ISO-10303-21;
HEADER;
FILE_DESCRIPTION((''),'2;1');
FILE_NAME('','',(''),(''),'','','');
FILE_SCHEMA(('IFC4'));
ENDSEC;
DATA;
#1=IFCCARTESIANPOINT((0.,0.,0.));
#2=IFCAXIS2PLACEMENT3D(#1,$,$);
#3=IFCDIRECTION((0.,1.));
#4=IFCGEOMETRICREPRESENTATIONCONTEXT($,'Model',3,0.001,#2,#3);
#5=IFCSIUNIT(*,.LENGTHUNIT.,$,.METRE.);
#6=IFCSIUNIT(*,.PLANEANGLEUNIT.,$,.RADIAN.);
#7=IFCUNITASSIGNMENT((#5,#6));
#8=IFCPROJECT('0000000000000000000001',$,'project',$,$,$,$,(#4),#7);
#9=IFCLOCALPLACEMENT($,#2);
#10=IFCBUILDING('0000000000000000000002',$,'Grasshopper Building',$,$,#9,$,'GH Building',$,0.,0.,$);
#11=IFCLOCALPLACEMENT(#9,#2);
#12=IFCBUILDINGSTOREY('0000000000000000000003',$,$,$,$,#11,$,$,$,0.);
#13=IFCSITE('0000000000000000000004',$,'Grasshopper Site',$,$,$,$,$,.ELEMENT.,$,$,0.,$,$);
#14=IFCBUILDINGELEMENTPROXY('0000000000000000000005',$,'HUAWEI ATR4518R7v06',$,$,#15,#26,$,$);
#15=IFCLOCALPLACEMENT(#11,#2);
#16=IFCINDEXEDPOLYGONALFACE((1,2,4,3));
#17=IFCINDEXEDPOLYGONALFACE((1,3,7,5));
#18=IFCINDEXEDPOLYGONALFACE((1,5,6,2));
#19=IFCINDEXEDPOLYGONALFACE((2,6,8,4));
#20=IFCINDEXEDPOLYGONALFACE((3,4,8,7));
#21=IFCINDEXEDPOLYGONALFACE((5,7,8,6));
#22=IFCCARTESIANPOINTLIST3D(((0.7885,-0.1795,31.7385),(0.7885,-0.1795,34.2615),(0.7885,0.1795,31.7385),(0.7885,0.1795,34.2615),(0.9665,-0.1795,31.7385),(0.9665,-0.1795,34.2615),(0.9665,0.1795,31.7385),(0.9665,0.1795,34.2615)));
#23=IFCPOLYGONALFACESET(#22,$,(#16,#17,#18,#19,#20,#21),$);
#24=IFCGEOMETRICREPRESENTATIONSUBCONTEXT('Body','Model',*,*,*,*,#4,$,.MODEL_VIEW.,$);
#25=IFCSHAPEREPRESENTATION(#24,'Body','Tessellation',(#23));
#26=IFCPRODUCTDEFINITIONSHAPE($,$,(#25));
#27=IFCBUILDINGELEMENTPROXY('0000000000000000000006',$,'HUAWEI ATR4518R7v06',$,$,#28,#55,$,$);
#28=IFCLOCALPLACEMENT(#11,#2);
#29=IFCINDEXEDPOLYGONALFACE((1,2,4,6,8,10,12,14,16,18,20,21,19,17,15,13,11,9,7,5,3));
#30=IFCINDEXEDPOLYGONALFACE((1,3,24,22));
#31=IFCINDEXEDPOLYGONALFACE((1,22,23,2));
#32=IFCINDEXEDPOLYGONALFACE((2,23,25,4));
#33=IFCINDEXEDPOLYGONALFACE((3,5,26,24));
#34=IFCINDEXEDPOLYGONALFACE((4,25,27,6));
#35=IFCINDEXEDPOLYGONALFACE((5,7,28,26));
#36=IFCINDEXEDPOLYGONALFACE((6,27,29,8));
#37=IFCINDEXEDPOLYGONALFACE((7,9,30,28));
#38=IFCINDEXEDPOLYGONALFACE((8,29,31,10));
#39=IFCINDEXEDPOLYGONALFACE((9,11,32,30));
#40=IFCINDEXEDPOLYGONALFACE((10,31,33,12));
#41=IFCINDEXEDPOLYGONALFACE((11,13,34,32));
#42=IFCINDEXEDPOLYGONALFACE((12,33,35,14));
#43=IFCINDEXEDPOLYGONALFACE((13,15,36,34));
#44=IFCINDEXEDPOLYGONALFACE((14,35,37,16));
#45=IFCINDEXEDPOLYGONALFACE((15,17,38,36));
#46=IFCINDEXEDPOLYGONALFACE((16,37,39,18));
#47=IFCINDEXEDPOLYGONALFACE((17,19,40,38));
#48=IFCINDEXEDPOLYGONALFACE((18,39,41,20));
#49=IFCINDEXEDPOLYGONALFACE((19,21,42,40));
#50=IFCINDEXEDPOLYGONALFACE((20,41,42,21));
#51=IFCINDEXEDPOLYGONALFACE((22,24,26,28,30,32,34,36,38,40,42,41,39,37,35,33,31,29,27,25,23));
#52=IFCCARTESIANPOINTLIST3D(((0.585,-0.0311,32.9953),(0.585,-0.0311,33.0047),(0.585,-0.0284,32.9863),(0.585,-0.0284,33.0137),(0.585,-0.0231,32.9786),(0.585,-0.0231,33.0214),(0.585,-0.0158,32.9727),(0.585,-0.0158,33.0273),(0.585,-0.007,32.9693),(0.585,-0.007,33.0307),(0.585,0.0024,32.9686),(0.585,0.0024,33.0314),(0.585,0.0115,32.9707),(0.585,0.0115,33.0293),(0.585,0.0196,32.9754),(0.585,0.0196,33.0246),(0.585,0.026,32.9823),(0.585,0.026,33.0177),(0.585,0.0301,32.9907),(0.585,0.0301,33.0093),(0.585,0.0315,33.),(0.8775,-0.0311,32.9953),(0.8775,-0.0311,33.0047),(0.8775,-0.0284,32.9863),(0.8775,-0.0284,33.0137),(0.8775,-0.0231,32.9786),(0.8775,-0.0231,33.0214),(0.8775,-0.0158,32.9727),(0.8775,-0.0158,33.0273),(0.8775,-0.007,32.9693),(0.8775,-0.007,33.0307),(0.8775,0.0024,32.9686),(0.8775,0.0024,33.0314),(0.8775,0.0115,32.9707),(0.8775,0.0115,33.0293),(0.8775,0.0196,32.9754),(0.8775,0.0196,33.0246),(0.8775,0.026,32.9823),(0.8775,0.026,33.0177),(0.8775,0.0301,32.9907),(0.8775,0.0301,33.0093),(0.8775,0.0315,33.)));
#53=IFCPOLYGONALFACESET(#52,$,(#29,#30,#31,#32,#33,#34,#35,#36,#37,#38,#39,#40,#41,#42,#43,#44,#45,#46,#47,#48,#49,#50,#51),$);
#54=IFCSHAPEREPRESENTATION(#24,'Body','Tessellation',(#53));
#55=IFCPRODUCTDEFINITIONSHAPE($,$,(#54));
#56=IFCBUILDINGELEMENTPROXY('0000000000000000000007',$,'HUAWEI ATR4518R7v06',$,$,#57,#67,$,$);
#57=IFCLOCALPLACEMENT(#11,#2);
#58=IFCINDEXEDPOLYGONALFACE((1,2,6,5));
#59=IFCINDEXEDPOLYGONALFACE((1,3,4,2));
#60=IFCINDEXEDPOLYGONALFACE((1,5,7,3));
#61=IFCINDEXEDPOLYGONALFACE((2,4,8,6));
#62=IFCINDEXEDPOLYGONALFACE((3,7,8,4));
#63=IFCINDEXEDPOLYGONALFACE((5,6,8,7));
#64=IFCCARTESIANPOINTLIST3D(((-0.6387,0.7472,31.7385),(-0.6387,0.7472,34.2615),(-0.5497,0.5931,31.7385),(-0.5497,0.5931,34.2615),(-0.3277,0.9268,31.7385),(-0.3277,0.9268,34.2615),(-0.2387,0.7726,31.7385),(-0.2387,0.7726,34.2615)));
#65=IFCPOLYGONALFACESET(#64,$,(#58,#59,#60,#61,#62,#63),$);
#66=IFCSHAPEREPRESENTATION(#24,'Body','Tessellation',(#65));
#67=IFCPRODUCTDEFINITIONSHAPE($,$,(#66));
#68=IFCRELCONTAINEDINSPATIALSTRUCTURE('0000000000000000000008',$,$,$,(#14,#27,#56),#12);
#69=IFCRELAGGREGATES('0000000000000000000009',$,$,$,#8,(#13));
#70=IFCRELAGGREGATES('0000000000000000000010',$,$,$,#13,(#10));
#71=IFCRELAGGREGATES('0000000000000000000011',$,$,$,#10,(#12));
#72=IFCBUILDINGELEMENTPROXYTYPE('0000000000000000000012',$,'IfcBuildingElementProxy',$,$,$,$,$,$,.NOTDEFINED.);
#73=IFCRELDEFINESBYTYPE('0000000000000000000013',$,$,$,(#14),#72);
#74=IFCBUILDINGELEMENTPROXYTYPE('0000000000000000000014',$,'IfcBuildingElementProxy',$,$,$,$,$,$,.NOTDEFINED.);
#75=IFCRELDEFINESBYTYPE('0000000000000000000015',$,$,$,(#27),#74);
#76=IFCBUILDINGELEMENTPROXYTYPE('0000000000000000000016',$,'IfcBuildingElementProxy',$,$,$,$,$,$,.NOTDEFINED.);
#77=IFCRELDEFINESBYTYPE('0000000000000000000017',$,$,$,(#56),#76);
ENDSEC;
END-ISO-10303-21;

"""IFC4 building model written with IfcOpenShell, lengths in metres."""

from ifc_helpers import new_model, si_unit, direction, frame, frame_2d, origin, place, context, subcontext, project, spatial, rectangle, circle, extrude, source, transform, mapped, type_object, type_shapes, element, save


model = new_model("IFC4")

# Units and contexts
model_context = context("Model", 3, precision=0.001, world=origin(), true_north=direction((0.0, 1.0)))
body_context = subcontext(model_context, "Body", "Model", "MODEL_VIEW")
ifc_project = project(units=[si_unit("LENGTHUNIT", "METRE"), si_unit("PLANEANGLEUNIT", "RADIAN")], contexts=[model_context])

# Site, building, storey
site = spatial("IfcSite", under=ifc_project, Name="Grasshopper Site", CompositionType="ELEMENT", RefElevation=0.0)
building_placement = place(None, origin())
building = spatial("IfcBuilding", under=site, at=building_placement, Name="Grasshopper Building", LongName="GH Building", ElevationOfRefHeight=0.0, ElevationOfTerrain=0.0)
storey_placement = place(building_placement, origin())
storey = spatial("IfcBuildingStorey", under=building, at=storey_placement, Elevation=0.0)

# Building element proxies
building_element_proxy_type_1 = type_object("IfcBuildingElementProxyType", Name="IfcBuildingElementProxy", PredefinedType="NOTDEFINED")
shared_shape_1 = source(origin(), body_context, "Body", "SweptSolid", [
    extrude(rectangle(XDim=2.523, YDim=0.359, at=frame_2d((0.0, 0.0), x_axis=(0.0, 1.0))), frame((0.9665, 0.0, 33.0), z_axis=(-1.0, 0.0, 0.0), x_axis=(0.0, 1.0, 0.0)), (0.0, 0.0, 1.0), 0.178),
])
type_shapes(building_element_proxy_type_1, [shared_shape_1])
for number, where, name in (
    (1, (0.0, 0.0, 0.0), "HUAWEI ATR4518R7v06"),
):
    element("IfcBuildingElementProxy", number, at=place(storey_placement, frame(where)), inside=storey, type_object=building_element_proxy_type_1, Name=name, context=body_context, shape_type="MappedRepresentation", body=[
        mapped(shared_shape_1, transform((0.0, 0.0, 0.0), scale=1.0)),
    ])
building_element_proxy_type_2 = type_object("IfcBuildingElementProxyType", Name="IfcBuildingElementProxy", PredefinedType="NOTDEFINED")
shared_shape_2 = source(origin(), body_context, "Body", "SweptSolid", [
    extrude(circle(Radius=0.0315), frame((0.585, 0.0, 33.0), z_axis=(1.0, 0.0, 0.0), x_axis=(0.0, 1.0, 0.0)), (0.0, 0.0, 1.0), 0.2925),
])
type_shapes(building_element_proxy_type_2, [shared_shape_2])
for number, where, name in (
    (2, (0.0, 0.0, 0.0), "HUAWEI ATR4518R7v06"),
):
    element("IfcBuildingElementProxy", number, at=place(storey_placement, frame(where)), inside=storey, type_object=building_element_proxy_type_2, Name=name, context=body_context, shape_type="MappedRepresentation", body=[
        mapped(shared_shape_2, transform((0.0, 0.0, 0.0), scale=1.0)),
    ])
building_element_proxy_type_3 = type_object("IfcBuildingElementProxyType", Name="IfcBuildingElementProxy", PredefinedType="NOTDEFINED")
shared_shape_3 = source(origin(), body_context, "Body", "SweptSolid", [
    extrude(rectangle(XDim=2.523, YDim=0.359, at=frame_2d((0.0, 0.0), x_axis=(0.0, 1.0))), frame((-0.4832, 0.837, 33.0), z_axis=(0.5, -0.866025, 0.0), x_axis=(-0.866025, -0.5, 0.0)), (0.0, 0.0, 1.0), 0.178),
])
type_shapes(building_element_proxy_type_3, [shared_shape_3])
for number, where, name in (
    (3, (0.0, 0.0, 0.0), "HUAWEI ATR4518R7v06"),
):
    element("IfcBuildingElementProxy", number, at=place(storey_placement, frame(where)), inside=storey, type_object=building_element_proxy_type_3, Name=name, context=body_context, shape_type="MappedRepresentation", body=[
        mapped(shared_shape_3, transform((0.0, 0.0, 0.0), scale=1.0)),
    ])

save(model, "model.ifc")
